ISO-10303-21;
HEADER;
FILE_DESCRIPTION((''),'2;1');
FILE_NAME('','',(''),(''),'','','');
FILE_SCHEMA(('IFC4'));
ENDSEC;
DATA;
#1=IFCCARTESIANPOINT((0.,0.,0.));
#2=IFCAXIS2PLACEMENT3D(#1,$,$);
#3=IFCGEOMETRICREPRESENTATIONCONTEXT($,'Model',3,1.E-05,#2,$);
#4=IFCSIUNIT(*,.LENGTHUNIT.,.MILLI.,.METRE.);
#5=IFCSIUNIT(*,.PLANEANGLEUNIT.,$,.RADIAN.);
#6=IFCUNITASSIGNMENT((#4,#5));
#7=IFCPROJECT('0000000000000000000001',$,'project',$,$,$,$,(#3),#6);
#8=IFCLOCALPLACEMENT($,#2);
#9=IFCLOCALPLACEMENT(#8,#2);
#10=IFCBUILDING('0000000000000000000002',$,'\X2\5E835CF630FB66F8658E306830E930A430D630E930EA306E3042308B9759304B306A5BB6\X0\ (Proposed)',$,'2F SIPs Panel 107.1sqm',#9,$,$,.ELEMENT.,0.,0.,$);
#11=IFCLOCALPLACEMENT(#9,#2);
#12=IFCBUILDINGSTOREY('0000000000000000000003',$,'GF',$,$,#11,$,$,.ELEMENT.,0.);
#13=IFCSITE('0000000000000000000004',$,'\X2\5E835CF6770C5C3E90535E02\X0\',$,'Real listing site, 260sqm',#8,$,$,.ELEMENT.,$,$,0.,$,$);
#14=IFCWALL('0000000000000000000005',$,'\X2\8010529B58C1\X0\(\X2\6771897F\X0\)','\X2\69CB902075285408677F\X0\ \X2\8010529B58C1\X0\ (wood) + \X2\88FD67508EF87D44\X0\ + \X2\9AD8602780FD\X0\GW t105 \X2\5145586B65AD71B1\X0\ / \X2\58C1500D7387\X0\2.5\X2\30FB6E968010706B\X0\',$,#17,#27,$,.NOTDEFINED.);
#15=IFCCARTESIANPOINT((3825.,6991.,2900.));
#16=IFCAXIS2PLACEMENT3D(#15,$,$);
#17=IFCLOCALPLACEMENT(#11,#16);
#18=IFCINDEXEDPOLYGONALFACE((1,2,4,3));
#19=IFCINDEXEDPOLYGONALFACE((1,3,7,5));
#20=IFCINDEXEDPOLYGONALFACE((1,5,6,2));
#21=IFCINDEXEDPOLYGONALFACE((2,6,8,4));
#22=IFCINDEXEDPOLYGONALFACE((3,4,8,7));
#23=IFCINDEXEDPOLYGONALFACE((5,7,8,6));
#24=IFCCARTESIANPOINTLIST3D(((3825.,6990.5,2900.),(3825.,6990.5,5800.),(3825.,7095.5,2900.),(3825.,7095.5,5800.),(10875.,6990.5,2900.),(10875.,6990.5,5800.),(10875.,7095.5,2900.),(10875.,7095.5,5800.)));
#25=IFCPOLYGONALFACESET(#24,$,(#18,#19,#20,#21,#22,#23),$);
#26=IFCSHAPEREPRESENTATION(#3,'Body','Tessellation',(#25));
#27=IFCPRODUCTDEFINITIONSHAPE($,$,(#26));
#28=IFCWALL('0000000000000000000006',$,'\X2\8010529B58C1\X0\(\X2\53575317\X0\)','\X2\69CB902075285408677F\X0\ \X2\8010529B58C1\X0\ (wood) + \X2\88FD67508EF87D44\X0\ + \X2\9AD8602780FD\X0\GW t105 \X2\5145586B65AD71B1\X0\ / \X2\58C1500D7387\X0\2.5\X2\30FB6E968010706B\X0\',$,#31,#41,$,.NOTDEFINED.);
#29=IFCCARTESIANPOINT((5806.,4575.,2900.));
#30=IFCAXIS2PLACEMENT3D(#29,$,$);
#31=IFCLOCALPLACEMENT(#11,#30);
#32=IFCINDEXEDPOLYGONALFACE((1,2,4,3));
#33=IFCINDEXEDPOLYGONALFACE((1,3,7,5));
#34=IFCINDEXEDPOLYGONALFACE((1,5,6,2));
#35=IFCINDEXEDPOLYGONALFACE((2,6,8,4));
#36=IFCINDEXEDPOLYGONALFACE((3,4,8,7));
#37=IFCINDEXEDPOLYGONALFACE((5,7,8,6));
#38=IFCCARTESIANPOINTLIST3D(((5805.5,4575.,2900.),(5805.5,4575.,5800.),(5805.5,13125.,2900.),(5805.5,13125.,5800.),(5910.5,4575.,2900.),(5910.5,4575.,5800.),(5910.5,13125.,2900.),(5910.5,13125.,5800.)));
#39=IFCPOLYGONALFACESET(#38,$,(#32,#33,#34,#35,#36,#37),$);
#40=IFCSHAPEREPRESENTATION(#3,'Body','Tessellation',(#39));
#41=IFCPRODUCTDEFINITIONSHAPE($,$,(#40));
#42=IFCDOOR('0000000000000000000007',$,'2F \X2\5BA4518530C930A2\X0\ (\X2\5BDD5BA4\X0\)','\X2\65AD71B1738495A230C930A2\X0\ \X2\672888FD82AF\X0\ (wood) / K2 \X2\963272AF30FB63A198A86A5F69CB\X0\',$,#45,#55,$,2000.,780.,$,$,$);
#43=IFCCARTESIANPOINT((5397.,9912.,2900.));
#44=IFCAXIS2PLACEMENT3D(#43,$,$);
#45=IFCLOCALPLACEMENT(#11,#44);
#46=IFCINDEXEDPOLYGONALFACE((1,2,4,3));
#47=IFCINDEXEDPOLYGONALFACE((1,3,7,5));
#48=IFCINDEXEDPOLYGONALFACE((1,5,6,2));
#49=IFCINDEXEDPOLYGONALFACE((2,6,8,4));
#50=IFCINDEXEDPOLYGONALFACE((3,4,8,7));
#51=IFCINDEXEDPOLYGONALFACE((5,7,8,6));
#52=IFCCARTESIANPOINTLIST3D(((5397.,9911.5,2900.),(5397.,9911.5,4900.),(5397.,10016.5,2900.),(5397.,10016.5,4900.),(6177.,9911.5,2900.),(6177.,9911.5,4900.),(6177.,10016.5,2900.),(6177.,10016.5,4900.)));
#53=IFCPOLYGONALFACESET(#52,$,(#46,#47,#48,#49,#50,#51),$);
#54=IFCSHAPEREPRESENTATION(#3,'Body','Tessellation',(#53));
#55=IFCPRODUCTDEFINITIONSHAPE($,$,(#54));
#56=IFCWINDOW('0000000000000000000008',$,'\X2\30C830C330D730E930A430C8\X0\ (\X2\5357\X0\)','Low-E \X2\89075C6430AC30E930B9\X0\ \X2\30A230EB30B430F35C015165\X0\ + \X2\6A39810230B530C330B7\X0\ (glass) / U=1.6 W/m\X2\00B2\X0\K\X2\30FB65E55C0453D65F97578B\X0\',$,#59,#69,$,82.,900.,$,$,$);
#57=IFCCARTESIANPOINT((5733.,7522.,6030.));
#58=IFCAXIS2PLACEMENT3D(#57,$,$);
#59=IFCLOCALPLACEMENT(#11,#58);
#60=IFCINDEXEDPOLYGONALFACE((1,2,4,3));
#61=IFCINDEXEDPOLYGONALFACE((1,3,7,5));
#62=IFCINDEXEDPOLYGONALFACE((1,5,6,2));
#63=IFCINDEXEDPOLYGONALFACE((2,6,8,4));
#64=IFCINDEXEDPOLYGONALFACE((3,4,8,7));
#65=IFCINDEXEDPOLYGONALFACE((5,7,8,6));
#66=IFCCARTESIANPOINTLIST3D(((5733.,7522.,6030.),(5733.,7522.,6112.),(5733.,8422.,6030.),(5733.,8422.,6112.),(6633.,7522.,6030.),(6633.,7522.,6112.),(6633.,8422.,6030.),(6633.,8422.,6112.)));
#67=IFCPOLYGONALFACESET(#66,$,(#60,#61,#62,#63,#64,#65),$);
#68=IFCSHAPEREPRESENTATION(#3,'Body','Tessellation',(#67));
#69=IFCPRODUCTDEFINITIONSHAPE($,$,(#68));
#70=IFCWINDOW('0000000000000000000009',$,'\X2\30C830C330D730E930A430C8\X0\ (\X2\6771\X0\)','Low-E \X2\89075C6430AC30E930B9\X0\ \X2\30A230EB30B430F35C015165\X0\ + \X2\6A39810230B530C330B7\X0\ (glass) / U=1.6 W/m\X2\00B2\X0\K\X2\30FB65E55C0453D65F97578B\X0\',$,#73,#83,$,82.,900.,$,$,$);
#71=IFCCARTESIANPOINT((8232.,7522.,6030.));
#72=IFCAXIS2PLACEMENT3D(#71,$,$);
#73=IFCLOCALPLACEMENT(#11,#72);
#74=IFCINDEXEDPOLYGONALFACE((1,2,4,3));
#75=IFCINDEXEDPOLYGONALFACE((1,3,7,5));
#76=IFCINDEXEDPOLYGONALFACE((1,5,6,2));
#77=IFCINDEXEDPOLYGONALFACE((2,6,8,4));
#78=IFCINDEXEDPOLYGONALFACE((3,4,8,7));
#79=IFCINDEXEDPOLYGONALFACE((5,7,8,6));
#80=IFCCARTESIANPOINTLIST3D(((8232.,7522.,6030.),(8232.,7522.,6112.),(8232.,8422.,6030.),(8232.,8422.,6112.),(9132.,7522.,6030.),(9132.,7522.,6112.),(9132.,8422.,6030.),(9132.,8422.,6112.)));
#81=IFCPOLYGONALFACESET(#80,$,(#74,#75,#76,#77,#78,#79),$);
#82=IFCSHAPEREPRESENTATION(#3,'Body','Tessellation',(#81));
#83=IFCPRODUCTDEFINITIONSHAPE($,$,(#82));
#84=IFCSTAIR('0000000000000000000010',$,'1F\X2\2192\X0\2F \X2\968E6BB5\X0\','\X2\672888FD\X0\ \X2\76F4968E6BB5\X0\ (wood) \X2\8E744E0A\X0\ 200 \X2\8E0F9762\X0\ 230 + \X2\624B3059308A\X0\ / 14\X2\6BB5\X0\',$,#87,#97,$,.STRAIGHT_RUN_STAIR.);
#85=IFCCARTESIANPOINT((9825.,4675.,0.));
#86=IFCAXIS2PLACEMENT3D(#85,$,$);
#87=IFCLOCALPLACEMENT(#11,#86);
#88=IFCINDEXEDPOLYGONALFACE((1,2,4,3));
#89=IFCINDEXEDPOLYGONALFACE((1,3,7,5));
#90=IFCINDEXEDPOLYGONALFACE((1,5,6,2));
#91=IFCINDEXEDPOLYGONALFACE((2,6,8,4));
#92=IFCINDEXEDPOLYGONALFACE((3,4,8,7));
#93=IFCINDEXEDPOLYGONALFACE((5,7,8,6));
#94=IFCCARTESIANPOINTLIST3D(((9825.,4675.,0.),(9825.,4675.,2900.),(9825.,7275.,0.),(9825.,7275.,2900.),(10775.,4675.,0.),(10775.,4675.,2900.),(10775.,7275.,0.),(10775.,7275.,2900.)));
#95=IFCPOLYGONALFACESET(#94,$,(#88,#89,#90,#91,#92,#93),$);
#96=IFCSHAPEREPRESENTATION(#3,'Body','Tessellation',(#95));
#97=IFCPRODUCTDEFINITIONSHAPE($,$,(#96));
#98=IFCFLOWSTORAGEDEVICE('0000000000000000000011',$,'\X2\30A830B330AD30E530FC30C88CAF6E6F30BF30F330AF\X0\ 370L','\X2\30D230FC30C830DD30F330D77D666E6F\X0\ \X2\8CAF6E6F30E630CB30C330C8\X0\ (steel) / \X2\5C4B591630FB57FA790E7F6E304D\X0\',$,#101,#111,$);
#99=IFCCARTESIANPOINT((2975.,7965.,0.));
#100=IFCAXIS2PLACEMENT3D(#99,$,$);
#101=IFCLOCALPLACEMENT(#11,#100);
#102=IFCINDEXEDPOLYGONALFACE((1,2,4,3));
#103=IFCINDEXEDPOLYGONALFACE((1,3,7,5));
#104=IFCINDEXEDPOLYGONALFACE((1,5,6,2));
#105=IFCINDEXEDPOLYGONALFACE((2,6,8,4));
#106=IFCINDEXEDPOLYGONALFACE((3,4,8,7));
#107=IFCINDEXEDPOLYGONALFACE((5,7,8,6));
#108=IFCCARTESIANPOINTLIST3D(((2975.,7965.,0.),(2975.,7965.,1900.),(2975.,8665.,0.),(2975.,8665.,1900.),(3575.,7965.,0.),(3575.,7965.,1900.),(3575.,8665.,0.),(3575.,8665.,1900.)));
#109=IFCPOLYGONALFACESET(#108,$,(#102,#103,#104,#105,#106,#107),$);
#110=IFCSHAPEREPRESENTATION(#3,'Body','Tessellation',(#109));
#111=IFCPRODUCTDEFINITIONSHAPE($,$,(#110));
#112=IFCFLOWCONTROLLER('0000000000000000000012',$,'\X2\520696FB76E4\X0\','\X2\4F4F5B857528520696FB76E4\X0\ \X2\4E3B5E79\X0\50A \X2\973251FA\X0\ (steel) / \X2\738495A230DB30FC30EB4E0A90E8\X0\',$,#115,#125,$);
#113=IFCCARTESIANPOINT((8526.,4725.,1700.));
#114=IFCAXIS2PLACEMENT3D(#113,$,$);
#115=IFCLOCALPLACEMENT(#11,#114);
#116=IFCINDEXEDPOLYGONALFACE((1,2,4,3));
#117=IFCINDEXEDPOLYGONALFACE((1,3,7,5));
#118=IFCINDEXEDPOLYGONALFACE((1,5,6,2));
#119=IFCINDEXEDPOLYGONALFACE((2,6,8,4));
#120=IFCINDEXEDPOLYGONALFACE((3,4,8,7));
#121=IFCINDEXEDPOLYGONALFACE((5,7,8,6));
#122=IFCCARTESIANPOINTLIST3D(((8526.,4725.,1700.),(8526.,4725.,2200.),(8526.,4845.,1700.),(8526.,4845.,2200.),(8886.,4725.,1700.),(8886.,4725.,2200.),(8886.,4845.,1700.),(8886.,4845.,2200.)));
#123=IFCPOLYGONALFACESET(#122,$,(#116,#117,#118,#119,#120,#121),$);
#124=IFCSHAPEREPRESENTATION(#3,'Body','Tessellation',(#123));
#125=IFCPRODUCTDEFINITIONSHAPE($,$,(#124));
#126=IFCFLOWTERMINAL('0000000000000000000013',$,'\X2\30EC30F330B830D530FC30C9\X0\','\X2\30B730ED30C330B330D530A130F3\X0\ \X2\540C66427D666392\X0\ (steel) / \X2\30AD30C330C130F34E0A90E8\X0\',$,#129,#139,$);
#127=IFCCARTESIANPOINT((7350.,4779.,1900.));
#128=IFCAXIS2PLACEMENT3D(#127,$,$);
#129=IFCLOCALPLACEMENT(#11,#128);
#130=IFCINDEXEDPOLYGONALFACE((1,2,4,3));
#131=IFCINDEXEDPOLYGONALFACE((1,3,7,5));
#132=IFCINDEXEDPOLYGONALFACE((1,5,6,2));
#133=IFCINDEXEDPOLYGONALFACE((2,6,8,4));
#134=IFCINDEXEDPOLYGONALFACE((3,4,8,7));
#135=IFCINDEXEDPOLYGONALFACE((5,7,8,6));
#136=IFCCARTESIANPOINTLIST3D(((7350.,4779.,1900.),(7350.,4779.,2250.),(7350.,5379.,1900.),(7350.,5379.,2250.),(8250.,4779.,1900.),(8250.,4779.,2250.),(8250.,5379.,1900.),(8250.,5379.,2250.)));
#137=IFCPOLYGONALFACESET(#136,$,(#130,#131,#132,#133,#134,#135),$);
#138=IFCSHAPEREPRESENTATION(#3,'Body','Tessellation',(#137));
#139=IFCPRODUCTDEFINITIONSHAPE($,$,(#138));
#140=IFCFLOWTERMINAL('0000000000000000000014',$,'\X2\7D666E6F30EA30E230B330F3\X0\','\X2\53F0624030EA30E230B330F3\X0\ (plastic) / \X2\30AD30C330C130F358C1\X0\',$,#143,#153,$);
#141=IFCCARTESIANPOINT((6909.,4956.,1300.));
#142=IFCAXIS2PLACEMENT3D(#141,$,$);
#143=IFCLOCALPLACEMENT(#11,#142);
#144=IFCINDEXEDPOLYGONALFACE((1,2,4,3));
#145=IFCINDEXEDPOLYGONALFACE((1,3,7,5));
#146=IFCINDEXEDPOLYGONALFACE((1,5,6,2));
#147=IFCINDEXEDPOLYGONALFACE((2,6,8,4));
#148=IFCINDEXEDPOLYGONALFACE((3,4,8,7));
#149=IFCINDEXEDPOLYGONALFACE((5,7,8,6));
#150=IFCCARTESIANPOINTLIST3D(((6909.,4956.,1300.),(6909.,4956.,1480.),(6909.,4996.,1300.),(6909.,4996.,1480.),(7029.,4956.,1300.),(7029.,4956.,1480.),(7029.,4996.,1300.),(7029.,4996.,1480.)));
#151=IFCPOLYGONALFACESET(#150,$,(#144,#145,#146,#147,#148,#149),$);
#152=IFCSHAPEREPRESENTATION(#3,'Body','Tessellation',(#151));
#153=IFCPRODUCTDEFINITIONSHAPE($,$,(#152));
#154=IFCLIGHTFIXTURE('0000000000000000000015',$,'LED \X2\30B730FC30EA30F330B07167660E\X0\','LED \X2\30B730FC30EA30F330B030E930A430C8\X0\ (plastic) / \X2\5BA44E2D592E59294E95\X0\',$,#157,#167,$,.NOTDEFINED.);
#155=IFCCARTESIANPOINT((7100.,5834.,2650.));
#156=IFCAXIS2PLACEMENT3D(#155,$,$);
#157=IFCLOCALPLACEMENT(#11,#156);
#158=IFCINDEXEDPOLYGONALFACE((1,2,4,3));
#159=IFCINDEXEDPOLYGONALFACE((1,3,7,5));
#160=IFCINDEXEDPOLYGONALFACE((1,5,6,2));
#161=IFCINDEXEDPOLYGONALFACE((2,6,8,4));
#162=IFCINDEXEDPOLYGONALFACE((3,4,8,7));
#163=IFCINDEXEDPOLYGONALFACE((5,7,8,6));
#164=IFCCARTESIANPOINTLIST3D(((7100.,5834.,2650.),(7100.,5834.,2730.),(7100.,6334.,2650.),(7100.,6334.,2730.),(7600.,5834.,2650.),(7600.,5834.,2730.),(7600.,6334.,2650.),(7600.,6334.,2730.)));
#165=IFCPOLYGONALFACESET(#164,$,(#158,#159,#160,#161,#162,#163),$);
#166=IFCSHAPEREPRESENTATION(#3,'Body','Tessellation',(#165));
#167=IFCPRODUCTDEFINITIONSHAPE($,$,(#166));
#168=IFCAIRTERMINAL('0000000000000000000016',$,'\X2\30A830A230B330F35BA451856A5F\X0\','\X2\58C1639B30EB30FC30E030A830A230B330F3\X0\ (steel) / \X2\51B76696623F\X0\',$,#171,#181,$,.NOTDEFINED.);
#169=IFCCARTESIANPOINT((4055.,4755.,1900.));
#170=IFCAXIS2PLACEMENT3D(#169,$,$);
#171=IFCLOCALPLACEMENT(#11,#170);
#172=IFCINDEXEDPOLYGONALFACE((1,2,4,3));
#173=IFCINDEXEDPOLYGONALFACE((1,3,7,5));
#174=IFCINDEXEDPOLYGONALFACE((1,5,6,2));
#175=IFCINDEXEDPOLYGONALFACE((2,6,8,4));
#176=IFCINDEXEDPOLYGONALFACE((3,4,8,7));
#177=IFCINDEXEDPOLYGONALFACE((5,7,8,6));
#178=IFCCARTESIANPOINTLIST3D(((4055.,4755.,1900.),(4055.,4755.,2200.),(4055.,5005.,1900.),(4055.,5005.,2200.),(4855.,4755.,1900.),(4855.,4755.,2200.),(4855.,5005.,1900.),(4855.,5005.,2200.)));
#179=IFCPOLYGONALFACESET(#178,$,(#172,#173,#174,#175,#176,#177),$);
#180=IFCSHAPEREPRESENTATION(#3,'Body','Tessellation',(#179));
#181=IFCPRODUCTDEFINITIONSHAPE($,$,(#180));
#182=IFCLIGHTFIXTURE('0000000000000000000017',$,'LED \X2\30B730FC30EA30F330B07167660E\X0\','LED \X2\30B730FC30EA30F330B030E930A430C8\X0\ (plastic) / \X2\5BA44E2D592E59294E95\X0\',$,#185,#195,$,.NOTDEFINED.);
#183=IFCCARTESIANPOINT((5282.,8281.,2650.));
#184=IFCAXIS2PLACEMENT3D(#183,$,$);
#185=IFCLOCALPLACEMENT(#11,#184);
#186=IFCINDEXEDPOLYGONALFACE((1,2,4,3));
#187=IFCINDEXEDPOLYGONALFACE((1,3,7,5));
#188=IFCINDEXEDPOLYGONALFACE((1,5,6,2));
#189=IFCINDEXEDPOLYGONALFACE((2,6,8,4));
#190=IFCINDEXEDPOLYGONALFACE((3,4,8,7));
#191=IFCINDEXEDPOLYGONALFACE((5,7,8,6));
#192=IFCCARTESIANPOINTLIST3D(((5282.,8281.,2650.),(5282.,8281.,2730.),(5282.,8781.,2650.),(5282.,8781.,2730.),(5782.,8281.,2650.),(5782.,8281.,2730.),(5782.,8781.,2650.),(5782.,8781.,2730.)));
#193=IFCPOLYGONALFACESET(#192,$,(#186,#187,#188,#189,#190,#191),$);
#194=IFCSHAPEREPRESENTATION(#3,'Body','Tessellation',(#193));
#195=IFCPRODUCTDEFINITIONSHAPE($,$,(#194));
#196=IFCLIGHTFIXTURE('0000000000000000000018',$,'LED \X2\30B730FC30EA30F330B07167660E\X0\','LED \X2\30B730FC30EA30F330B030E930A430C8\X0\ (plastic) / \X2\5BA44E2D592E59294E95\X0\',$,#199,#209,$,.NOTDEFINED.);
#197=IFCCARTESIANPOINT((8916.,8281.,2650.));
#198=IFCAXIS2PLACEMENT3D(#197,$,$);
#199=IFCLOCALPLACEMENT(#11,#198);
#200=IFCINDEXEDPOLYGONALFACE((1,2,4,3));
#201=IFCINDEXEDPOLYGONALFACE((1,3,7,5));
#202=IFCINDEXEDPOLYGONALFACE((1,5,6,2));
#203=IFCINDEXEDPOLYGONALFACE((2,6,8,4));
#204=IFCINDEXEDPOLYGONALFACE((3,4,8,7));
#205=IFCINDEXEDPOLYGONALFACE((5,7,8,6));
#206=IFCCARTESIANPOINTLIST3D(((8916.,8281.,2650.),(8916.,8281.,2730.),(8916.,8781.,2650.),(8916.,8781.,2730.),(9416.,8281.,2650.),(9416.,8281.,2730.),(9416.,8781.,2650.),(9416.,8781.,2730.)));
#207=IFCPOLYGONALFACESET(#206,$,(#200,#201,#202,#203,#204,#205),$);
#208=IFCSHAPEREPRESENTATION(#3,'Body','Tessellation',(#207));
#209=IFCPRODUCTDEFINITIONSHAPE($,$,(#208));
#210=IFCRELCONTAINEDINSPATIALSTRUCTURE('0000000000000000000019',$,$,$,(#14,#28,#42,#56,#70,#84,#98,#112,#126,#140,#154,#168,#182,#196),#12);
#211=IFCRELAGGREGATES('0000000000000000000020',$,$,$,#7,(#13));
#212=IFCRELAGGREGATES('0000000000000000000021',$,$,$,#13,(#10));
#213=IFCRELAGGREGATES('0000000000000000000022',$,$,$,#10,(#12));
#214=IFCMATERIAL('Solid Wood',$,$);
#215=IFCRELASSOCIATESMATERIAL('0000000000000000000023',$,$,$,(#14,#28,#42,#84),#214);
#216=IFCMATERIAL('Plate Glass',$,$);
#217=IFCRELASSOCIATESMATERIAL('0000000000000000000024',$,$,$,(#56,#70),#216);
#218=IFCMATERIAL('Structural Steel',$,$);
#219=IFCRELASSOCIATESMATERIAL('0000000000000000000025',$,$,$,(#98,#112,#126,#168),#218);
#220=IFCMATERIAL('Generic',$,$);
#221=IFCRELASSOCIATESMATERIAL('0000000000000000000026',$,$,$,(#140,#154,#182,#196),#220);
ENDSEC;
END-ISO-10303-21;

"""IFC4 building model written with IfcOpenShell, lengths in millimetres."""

from ifc_helpers import new_model, si_unit, frame, frame_2d, origin, place, context, project, spatial, rectangle, extrude, material, element, fill, save


model = new_model("IFC4")

# Units and contexts
model_context = context("Model", 3, precision=1e-05, world=origin())
ifc_project = project(units=[si_unit("LENGTHUNIT", "METRE", prefix="MILLI"), si_unit("PLANEANGLEUNIT", "RADIAN")], contexts=[model_context])

# Site, building, storey
site_placement = place(None, origin())
site = spatial("IfcSite", under=ifc_project, at=site_placement, Name="広島県尾道市", ObjectType="Real listing site, 260sqm", CompositionType="ELEMENT", RefElevation=0.0)
building_placement = place(site_placement, origin())
building = spatial("IfcBuilding", under=site, at=building_placement, Name="広島・書斎とライブラリのある静かな家 (Proposed)", ObjectType="2F SIPs Panel 107.1sqm", CompositionType="ELEMENT", ElevationOfRefHeight=0.0, ElevationOfTerrain=0.0)
storey_placement = place(building_placement, origin())
storey = spatial("IfcBuildingStorey", under=building, at=storey_placement, Name="GF", CompositionType="ELEMENT", Elevation=0.0)

# Shared definitions
ifc_material_1 = material(Name="Solid Wood")

# Wall
wall_1_placement = place(storey_placement, frame((3825.0, 6991.0, 2900.0)))
element("IfcWall", 1, at=wall_1_placement, inside=storey, material=ifc_material_1, Name="耐力壁(東西)", Description="構造用合板 耐力壁 (wood) + 製材軸組 + 高性能GW t105 充填断熱 / 壁倍率2.5・準耐火", PredefinedType="NOTDEFINED", context=model_context, shape_type="SweptSolid", body=[
    extrude(rectangle(XDim=7050.0, YDim=105.0, at=frame_2d((3525.0, 52.0))), frame((3825.0, 6991.0, 2900.0)), (0.0, 0.0, 1.0), 2900.0),
])

# Wall, opening, door
wall_2_placement = place(storey_placement, frame((5806.0, 4575.0, 2900.0)))
wall_2 = element("IfcWall", 2, at=wall_2_placement, inside=storey, material=ifc_material_1, Name="耐力壁(南北)", Description="構造用合板 耐力壁 (wood) + 製材軸組 + 高性能GW t105 充填断熱 / 壁倍率2.5・準耐火", PredefinedType="NOTDEFINED", context=model_context, shape_type="SweptSolid", body=[
    extrude(rectangle(XDim=105.0, YDim=8550.0, at=frame_2d((52.0, 4275.0))), frame((5806.0, 4575.0, 2900.0)), (0.0, 0.0, 1.0), 2900.0),
])
opening_placement = place(storey_placement, frame((5397.0, 9912.0, 2900.0)))
opening = element("IfcOpeningElement", 3, at=opening_placement, cuts=wall_2, PredefinedType="NOTDEFINED", context=model_context, shape_type="SweptSolid", body=[
    extrude(rectangle(XDim=780.0, YDim=105.0, at=frame_2d((390.0, 52.0))), frame((5397.0, 9912.0, 2900.0)), (0.0, 0.0, 1.0), 2000.0),
])
door_placement = place(storey_placement, frame((5397.0, 9912.0, 2900.0)))
door = element("IfcDoor", 4, at=door_placement, inside=storey, material=ifc_material_1, Name="2F 室内ドア (寝室)", Description="断熱玄関ドア 木製芯 (wood) / K2 防犯・採風機構", OverallHeight=2000.0, OverallWidth=780.0, context=model_context, shape_type="SweptSolid", body=[
    extrude(rectangle(XDim=780.0, YDim=105.0, at=frame_2d((390.0, 52.0))), frame((5397.0, 9912.0, 2900.0)), (0.0, 0.0, 1.0), 2000.0),
])
fill(opening, door)

# Windows
ifc_material_2 = material(Name="Plate Glass")
window_1_placement = place(storey_placement, frame((5733.0, 7522.0, 6030.0)))
element("IfcWindow", 5, at=window_1_placement, inside=storey, material=ifc_material_2, Name="トップライト (南)", Description="Low-E 複層ガラス アルゴン封入 + 樹脂サッシ (glass) / U=1.6 W/m²K・日射取得型", OverallHeight=82.0, OverallWidth=900.0, context=model_context, shape_type="SweptSolid", body=[
    extrude(rectangle(XDim=900.0, YDim=900.0, at=frame_2d((450.0, 450.0))), frame((5733.0, 7522.0, 6030.0)), (0.0, 0.0, 1.0), 82.0),
])
window_2_placement = place(storey_placement, frame((8232.0, 7522.0, 6030.0)))
element("IfcWindow", 6, at=window_2_placement, inside=storey, material=ifc_material_2, Name="トップライト (東)", Description="Low-E 複層ガラス アルゴン封入 + 樹脂サッシ (glass) / U=1.6 W/m²K・日射取得型", OverallHeight=82.0, OverallWidth=900.0, context=model_context, shape_type="SweptSolid", body=[
    extrude(rectangle(XDim=900.0, YDim=900.0, at=frame_2d((450.0, 450.0))), frame((8232.0, 7522.0, 6030.0)), (0.0, 0.0, 1.0), 82.0),
])

# Stair
stair_placement = place(storey_placement, frame((9825.0, 4675.0, 0.0)))
element("IfcStair", 7, at=stair_placement, inside=storey, material=ifc_material_1, Name="1F→2F 階段", Description="木製 直階段 (wood) 蹴上 200 踏面 230 + 手すり / 14段", PredefinedType="STRAIGHT_RUN_STAIR", context=model_context, shape_type="SweptSolid", body=[
    extrude(rectangle(XDim=950.0, YDim=2600.0, at=frame_2d((475.0, 1300.0))), frame((9825.0, 4675.0, 0.0)), (0.0, 0.0, 1.0), 2900.0),
])

# Flow storage device
ifc_material_3 = material(Name="Structural Steel")
flow_storage_device_placement = place(storey_placement, frame((2975.0, 7965.0, 0.0)))
element("IfcFlowStorageDevice", 8, at=flow_storage_device_placement, inside=storey, material=ifc_material_3, Name="エコキュート貯湯タンク 370L", Description="ヒートポンプ給湯 貯湯ユニット (steel) / 屋外・基礎置き", context=model_context, shape_type="SweptSolid", body=[
    extrude(rectangle(XDim=600.0, YDim=700.0, at=frame_2d((300.0, 350.0))), frame((2975.0, 7965.0, 0.0)), (0.0, 0.0, 1.0), 1900.0),
])

# Flow controller
flow_controller_placement = place(storey_placement, frame((8526.0, 4725.0, 1700.0)))
element("IfcFlowController", 9, at=flow_controller_placement, inside=storey, material=ifc_material_3, Name="分電盤", Description="住宅用分電盤 主幹50A 露出 (steel) / 玄関ホール上部", context=model_context, shape_type="SweptSolid", body=[
    extrude(rectangle(XDim=360.0, YDim=120.0, at=frame_2d((180.0, 60.0))), frame((8526.0, 4725.0, 1700.0)), (0.0, 0.0, 1.0), 500.0),
])

# Flow terminals
flow_terminal_1_placement = place(storey_placement, frame((7350.0, 4779.0, 1900.0)))
element("IfcFlowTerminal", 10, at=flow_terminal_1_placement, inside=storey, material=ifc_material_3, Name="レンジフード", Description="シロッコファン 同時給排 (steel) / キッチン上部", context=model_context, shape_type="SweptSolid", body=[
    extrude(rectangle(XDim=900.0, YDim=600.0, at=frame_2d((450.0, 300.0))), frame((7350.0, 4779.0, 1900.0)), (0.0, 0.0, 1.0), 350.0),
])
ifc_material_4 = material(Name="Generic")
flow_terminal_2_placement = place(storey_placement, frame((6909.0, 4956.0, 1300.0)))
element("IfcFlowTerminal", 11, at=flow_terminal_2_placement, inside=storey, material=ifc_material_4, Name="給湯リモコン", Description="台所リモコン (plastic) / キッチン壁", context=model_context, shape_type="SweptSolid", body=[
    extrude(rectangle(XDim=120.0, YDim=40.0, at=frame_2d((60.0, 20.0))), frame((6909.0, 4956.0, 1300.0)), (0.0, 0.0, 1.0), 180.0),
])

# Light fixture
light_fixture_1_placement = place(storey_placement, frame((7100.0, 5834.0, 2650.0)))
element("IfcLightFixture", 12, at=light_fixture_1_placement, inside=storey, material=ifc_material_4, Name="LED シーリング照明", Description="LED シーリングライト (plastic) / 室中央天井", PredefinedType="NOTDEFINED", context=model_context, shape_type="SweptSolid", body=[
    extrude(rectangle(XDim=500.0, YDim=500.0, at=frame_2d((250.0, 250.0))), frame((7100.0, 5834.0, 2650.0)), (0.0, 0.0, 1.0), 80.0),
])

# Air terminal
air_terminal_1_placement = place(storey_placement, frame((4055.0, 4755.0, 1900.0)))
element("IfcAirTerminal", 13, at=air_terminal_1_placement, inside=storey, material=ifc_material_3, Name="エアコン室内機", Description="壁掛ルームエアコン (steel) / 冷暖房", PredefinedType="NOTDEFINED", context=model_context, shape_type="SweptSolid", body=[
    extrude(rectangle(XDim=800.0, YDim=250.0, at=frame_2d((400.0, 125.0))), frame((4055.0, 4755.0, 1900.0)), (0.0, 0.0, 1.0), 300.0),
])

# Light fixtures
light_fixture_2_placement = place(storey_placement, frame((5282.0, 8281.0, 2650.0)))
element("IfcLightFixture", 14, at=light_fixture_2_placement, inside=storey, material=ifc_material_4, Name="LED シーリング照明", Description="LED シーリングライト (plastic) / 室中央天井", PredefinedType="NOTDEFINED", context=model_context, shape_type="SweptSolid", body=[
    extrude(rectangle(XDim=500.0, YDim=500.0, at=frame_2d((250.0, 250.0))), frame((5282.0, 8281.0, 2650.0)), (0.0, 0.0, 1.0), 80.0),
])
light_fixture_3_placement = place(storey_placement, frame((8916.0, 8281.0, 2650.0)))
element("IfcLightFixture", 15, at=light_fixture_3_placement, inside=storey, material=ifc_material_4, Name="LED シーリング照明", Description="LED シーリングライト (plastic) / 室中央天井", PredefinedType="NOTDEFINED", context=model_context, shape_type="SweptSolid", body=[
    extrude(rectangle(XDim=500.0, YDim=500.0, at=frame_2d((250.0, 250.0))), frame((8916.0, 8281.0, 2650.0)), (0.0, 0.0, 1.0), 80.0),
])

save(model, "model.ifc")
